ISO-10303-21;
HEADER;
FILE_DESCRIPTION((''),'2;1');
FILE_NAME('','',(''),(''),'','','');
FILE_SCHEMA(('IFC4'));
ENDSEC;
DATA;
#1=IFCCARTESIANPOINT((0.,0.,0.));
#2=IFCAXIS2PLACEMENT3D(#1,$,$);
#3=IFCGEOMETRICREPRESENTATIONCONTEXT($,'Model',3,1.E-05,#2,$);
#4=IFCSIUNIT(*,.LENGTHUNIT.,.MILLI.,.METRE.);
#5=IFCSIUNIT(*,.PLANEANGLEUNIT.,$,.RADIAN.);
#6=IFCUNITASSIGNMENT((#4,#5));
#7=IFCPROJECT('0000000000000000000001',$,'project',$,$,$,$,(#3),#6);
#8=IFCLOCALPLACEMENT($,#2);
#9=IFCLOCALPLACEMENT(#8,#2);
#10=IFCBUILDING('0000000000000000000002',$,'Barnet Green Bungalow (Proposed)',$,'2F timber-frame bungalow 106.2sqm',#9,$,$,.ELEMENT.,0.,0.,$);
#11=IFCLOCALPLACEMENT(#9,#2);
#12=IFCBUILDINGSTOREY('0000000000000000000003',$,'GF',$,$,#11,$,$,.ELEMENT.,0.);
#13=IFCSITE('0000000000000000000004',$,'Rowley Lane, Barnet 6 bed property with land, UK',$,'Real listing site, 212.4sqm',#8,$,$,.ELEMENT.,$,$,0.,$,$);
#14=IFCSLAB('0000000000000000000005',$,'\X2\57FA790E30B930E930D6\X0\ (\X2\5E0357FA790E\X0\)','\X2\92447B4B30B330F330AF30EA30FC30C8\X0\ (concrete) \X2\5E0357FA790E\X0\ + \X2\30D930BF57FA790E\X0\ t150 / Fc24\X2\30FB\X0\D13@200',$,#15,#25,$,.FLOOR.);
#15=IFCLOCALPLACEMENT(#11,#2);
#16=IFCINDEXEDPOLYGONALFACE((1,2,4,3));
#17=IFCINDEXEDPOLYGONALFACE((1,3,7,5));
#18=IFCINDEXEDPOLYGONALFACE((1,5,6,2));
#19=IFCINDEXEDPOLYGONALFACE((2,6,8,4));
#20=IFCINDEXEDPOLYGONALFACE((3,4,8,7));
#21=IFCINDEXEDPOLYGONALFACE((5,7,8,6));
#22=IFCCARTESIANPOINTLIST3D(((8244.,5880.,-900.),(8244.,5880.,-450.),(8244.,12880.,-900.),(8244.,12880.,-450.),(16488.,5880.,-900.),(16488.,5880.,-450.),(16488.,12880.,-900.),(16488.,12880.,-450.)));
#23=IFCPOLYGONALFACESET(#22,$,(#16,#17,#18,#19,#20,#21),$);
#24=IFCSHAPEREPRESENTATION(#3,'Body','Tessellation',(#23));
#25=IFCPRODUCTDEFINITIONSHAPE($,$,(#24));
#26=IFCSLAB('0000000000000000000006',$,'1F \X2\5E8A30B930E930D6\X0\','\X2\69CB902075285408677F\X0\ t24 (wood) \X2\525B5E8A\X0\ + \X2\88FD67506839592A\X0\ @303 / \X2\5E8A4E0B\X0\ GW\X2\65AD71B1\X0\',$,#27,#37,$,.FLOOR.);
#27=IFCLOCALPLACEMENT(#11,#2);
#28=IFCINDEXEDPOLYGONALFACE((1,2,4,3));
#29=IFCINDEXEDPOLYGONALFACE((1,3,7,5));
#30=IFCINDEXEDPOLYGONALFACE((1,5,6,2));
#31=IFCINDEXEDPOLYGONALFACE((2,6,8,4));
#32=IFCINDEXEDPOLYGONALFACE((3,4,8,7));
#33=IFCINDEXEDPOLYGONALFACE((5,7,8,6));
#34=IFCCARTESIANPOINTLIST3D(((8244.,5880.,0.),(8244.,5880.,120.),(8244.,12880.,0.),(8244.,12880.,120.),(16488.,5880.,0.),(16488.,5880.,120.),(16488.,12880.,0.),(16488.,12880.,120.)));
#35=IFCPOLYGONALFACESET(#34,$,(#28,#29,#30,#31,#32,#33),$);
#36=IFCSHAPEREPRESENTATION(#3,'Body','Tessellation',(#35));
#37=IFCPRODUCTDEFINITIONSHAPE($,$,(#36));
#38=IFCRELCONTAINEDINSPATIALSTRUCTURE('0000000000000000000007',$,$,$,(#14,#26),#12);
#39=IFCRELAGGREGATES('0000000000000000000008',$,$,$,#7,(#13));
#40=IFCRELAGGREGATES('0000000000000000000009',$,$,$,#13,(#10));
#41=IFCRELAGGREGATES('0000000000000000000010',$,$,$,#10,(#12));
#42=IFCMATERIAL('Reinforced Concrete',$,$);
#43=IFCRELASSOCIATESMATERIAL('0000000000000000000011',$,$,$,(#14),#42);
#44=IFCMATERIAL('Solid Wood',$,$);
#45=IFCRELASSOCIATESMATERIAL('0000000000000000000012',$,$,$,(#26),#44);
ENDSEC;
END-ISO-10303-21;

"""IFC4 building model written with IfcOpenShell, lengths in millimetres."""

from ifc_helpers import new_model, si_unit, frame, frame_2d, origin, place, context, project, spatial, rectangle, extrude, material, element, save


model = new_model("IFC4")

# Units and contexts
model_context = context("Model", 3, precision=1e-05, world=origin())
ifc_project = project(units=[si_unit("LENGTHUNIT", "METRE", prefix="MILLI"), si_unit("PLANEANGLEUNIT", "RADIAN")], contexts=[model_context])

# Site, building, storey
site_placement = place(None, origin())
site = spatial("IfcSite", under=ifc_project, at=site_placement, Name="Rowley Lane, Barnet 6 bed property with land, UK", ObjectType="Real listing site, 212.4sqm", CompositionType="ELEMENT", RefElevation=0.0)
building_placement = place(site_placement, origin())
building = spatial("IfcBuilding", under=site, at=building_placement, Name="Barnet Green Bungalow (Proposed)", ObjectType="2F timber-frame bungalow 106.2sqm", CompositionType="ELEMENT", ElevationOfRefHeight=0.0, ElevationOfTerrain=0.0)
storey_placement = place(building_placement, origin())
storey = spatial("IfcBuildingStorey", under=building, at=storey_placement, Name="GF", CompositionType="ELEMENT", Elevation=0.0)

# Slabs
ifc_material_1 = material(Name="Reinforced Concrete")
slab_1_placement = place(storey_placement, frame((4122.0, 2940.0, -450.0)))
element("IfcSlab", 1, at=slab_1_placement, inside=storey, material=ifc_material_1, Name="基礎スラブ (布基礎)", Description="鉄筋コンクリート (concrete) 布基礎 + ベタ基礎 t150 / Fc24・D13@200", PredefinedType="FLOOR", context=model_context, shape_type="SweptSolid", body=[
    extrude(rectangle(XDim=8244.0, YDim=7000.0, at=frame_2d((4122.0, 3500.0))), frame((4122.0, 2940.0, -450.0)), (0.0, 0.0, 1.0), 450.0),
])
ifc_material_2 = material(Name="Solid Wood")
slab_2_placement = place(storey_placement, frame((4122.0, 2940.0, 0.0)))
element("IfcSlab", 2, at=slab_2_placement, inside=storey, material=ifc_material_2, Name="1F 床スラブ", Description="構造用合板 t24 (wood) 剛床 + 製材根太 @303 / 床下 GW断熱", PredefinedType="FLOOR", context=model_context, shape_type="SweptSolid", body=[
    extrude(rectangle(XDim=8244.0, YDim=7000.0, at=frame_2d((4122.0, 3500.0))), frame((4122.0, 2940.0, 0.0)), (0.0, 0.0, 1.0), 120.0),
])

save(model, "model.ifc")
